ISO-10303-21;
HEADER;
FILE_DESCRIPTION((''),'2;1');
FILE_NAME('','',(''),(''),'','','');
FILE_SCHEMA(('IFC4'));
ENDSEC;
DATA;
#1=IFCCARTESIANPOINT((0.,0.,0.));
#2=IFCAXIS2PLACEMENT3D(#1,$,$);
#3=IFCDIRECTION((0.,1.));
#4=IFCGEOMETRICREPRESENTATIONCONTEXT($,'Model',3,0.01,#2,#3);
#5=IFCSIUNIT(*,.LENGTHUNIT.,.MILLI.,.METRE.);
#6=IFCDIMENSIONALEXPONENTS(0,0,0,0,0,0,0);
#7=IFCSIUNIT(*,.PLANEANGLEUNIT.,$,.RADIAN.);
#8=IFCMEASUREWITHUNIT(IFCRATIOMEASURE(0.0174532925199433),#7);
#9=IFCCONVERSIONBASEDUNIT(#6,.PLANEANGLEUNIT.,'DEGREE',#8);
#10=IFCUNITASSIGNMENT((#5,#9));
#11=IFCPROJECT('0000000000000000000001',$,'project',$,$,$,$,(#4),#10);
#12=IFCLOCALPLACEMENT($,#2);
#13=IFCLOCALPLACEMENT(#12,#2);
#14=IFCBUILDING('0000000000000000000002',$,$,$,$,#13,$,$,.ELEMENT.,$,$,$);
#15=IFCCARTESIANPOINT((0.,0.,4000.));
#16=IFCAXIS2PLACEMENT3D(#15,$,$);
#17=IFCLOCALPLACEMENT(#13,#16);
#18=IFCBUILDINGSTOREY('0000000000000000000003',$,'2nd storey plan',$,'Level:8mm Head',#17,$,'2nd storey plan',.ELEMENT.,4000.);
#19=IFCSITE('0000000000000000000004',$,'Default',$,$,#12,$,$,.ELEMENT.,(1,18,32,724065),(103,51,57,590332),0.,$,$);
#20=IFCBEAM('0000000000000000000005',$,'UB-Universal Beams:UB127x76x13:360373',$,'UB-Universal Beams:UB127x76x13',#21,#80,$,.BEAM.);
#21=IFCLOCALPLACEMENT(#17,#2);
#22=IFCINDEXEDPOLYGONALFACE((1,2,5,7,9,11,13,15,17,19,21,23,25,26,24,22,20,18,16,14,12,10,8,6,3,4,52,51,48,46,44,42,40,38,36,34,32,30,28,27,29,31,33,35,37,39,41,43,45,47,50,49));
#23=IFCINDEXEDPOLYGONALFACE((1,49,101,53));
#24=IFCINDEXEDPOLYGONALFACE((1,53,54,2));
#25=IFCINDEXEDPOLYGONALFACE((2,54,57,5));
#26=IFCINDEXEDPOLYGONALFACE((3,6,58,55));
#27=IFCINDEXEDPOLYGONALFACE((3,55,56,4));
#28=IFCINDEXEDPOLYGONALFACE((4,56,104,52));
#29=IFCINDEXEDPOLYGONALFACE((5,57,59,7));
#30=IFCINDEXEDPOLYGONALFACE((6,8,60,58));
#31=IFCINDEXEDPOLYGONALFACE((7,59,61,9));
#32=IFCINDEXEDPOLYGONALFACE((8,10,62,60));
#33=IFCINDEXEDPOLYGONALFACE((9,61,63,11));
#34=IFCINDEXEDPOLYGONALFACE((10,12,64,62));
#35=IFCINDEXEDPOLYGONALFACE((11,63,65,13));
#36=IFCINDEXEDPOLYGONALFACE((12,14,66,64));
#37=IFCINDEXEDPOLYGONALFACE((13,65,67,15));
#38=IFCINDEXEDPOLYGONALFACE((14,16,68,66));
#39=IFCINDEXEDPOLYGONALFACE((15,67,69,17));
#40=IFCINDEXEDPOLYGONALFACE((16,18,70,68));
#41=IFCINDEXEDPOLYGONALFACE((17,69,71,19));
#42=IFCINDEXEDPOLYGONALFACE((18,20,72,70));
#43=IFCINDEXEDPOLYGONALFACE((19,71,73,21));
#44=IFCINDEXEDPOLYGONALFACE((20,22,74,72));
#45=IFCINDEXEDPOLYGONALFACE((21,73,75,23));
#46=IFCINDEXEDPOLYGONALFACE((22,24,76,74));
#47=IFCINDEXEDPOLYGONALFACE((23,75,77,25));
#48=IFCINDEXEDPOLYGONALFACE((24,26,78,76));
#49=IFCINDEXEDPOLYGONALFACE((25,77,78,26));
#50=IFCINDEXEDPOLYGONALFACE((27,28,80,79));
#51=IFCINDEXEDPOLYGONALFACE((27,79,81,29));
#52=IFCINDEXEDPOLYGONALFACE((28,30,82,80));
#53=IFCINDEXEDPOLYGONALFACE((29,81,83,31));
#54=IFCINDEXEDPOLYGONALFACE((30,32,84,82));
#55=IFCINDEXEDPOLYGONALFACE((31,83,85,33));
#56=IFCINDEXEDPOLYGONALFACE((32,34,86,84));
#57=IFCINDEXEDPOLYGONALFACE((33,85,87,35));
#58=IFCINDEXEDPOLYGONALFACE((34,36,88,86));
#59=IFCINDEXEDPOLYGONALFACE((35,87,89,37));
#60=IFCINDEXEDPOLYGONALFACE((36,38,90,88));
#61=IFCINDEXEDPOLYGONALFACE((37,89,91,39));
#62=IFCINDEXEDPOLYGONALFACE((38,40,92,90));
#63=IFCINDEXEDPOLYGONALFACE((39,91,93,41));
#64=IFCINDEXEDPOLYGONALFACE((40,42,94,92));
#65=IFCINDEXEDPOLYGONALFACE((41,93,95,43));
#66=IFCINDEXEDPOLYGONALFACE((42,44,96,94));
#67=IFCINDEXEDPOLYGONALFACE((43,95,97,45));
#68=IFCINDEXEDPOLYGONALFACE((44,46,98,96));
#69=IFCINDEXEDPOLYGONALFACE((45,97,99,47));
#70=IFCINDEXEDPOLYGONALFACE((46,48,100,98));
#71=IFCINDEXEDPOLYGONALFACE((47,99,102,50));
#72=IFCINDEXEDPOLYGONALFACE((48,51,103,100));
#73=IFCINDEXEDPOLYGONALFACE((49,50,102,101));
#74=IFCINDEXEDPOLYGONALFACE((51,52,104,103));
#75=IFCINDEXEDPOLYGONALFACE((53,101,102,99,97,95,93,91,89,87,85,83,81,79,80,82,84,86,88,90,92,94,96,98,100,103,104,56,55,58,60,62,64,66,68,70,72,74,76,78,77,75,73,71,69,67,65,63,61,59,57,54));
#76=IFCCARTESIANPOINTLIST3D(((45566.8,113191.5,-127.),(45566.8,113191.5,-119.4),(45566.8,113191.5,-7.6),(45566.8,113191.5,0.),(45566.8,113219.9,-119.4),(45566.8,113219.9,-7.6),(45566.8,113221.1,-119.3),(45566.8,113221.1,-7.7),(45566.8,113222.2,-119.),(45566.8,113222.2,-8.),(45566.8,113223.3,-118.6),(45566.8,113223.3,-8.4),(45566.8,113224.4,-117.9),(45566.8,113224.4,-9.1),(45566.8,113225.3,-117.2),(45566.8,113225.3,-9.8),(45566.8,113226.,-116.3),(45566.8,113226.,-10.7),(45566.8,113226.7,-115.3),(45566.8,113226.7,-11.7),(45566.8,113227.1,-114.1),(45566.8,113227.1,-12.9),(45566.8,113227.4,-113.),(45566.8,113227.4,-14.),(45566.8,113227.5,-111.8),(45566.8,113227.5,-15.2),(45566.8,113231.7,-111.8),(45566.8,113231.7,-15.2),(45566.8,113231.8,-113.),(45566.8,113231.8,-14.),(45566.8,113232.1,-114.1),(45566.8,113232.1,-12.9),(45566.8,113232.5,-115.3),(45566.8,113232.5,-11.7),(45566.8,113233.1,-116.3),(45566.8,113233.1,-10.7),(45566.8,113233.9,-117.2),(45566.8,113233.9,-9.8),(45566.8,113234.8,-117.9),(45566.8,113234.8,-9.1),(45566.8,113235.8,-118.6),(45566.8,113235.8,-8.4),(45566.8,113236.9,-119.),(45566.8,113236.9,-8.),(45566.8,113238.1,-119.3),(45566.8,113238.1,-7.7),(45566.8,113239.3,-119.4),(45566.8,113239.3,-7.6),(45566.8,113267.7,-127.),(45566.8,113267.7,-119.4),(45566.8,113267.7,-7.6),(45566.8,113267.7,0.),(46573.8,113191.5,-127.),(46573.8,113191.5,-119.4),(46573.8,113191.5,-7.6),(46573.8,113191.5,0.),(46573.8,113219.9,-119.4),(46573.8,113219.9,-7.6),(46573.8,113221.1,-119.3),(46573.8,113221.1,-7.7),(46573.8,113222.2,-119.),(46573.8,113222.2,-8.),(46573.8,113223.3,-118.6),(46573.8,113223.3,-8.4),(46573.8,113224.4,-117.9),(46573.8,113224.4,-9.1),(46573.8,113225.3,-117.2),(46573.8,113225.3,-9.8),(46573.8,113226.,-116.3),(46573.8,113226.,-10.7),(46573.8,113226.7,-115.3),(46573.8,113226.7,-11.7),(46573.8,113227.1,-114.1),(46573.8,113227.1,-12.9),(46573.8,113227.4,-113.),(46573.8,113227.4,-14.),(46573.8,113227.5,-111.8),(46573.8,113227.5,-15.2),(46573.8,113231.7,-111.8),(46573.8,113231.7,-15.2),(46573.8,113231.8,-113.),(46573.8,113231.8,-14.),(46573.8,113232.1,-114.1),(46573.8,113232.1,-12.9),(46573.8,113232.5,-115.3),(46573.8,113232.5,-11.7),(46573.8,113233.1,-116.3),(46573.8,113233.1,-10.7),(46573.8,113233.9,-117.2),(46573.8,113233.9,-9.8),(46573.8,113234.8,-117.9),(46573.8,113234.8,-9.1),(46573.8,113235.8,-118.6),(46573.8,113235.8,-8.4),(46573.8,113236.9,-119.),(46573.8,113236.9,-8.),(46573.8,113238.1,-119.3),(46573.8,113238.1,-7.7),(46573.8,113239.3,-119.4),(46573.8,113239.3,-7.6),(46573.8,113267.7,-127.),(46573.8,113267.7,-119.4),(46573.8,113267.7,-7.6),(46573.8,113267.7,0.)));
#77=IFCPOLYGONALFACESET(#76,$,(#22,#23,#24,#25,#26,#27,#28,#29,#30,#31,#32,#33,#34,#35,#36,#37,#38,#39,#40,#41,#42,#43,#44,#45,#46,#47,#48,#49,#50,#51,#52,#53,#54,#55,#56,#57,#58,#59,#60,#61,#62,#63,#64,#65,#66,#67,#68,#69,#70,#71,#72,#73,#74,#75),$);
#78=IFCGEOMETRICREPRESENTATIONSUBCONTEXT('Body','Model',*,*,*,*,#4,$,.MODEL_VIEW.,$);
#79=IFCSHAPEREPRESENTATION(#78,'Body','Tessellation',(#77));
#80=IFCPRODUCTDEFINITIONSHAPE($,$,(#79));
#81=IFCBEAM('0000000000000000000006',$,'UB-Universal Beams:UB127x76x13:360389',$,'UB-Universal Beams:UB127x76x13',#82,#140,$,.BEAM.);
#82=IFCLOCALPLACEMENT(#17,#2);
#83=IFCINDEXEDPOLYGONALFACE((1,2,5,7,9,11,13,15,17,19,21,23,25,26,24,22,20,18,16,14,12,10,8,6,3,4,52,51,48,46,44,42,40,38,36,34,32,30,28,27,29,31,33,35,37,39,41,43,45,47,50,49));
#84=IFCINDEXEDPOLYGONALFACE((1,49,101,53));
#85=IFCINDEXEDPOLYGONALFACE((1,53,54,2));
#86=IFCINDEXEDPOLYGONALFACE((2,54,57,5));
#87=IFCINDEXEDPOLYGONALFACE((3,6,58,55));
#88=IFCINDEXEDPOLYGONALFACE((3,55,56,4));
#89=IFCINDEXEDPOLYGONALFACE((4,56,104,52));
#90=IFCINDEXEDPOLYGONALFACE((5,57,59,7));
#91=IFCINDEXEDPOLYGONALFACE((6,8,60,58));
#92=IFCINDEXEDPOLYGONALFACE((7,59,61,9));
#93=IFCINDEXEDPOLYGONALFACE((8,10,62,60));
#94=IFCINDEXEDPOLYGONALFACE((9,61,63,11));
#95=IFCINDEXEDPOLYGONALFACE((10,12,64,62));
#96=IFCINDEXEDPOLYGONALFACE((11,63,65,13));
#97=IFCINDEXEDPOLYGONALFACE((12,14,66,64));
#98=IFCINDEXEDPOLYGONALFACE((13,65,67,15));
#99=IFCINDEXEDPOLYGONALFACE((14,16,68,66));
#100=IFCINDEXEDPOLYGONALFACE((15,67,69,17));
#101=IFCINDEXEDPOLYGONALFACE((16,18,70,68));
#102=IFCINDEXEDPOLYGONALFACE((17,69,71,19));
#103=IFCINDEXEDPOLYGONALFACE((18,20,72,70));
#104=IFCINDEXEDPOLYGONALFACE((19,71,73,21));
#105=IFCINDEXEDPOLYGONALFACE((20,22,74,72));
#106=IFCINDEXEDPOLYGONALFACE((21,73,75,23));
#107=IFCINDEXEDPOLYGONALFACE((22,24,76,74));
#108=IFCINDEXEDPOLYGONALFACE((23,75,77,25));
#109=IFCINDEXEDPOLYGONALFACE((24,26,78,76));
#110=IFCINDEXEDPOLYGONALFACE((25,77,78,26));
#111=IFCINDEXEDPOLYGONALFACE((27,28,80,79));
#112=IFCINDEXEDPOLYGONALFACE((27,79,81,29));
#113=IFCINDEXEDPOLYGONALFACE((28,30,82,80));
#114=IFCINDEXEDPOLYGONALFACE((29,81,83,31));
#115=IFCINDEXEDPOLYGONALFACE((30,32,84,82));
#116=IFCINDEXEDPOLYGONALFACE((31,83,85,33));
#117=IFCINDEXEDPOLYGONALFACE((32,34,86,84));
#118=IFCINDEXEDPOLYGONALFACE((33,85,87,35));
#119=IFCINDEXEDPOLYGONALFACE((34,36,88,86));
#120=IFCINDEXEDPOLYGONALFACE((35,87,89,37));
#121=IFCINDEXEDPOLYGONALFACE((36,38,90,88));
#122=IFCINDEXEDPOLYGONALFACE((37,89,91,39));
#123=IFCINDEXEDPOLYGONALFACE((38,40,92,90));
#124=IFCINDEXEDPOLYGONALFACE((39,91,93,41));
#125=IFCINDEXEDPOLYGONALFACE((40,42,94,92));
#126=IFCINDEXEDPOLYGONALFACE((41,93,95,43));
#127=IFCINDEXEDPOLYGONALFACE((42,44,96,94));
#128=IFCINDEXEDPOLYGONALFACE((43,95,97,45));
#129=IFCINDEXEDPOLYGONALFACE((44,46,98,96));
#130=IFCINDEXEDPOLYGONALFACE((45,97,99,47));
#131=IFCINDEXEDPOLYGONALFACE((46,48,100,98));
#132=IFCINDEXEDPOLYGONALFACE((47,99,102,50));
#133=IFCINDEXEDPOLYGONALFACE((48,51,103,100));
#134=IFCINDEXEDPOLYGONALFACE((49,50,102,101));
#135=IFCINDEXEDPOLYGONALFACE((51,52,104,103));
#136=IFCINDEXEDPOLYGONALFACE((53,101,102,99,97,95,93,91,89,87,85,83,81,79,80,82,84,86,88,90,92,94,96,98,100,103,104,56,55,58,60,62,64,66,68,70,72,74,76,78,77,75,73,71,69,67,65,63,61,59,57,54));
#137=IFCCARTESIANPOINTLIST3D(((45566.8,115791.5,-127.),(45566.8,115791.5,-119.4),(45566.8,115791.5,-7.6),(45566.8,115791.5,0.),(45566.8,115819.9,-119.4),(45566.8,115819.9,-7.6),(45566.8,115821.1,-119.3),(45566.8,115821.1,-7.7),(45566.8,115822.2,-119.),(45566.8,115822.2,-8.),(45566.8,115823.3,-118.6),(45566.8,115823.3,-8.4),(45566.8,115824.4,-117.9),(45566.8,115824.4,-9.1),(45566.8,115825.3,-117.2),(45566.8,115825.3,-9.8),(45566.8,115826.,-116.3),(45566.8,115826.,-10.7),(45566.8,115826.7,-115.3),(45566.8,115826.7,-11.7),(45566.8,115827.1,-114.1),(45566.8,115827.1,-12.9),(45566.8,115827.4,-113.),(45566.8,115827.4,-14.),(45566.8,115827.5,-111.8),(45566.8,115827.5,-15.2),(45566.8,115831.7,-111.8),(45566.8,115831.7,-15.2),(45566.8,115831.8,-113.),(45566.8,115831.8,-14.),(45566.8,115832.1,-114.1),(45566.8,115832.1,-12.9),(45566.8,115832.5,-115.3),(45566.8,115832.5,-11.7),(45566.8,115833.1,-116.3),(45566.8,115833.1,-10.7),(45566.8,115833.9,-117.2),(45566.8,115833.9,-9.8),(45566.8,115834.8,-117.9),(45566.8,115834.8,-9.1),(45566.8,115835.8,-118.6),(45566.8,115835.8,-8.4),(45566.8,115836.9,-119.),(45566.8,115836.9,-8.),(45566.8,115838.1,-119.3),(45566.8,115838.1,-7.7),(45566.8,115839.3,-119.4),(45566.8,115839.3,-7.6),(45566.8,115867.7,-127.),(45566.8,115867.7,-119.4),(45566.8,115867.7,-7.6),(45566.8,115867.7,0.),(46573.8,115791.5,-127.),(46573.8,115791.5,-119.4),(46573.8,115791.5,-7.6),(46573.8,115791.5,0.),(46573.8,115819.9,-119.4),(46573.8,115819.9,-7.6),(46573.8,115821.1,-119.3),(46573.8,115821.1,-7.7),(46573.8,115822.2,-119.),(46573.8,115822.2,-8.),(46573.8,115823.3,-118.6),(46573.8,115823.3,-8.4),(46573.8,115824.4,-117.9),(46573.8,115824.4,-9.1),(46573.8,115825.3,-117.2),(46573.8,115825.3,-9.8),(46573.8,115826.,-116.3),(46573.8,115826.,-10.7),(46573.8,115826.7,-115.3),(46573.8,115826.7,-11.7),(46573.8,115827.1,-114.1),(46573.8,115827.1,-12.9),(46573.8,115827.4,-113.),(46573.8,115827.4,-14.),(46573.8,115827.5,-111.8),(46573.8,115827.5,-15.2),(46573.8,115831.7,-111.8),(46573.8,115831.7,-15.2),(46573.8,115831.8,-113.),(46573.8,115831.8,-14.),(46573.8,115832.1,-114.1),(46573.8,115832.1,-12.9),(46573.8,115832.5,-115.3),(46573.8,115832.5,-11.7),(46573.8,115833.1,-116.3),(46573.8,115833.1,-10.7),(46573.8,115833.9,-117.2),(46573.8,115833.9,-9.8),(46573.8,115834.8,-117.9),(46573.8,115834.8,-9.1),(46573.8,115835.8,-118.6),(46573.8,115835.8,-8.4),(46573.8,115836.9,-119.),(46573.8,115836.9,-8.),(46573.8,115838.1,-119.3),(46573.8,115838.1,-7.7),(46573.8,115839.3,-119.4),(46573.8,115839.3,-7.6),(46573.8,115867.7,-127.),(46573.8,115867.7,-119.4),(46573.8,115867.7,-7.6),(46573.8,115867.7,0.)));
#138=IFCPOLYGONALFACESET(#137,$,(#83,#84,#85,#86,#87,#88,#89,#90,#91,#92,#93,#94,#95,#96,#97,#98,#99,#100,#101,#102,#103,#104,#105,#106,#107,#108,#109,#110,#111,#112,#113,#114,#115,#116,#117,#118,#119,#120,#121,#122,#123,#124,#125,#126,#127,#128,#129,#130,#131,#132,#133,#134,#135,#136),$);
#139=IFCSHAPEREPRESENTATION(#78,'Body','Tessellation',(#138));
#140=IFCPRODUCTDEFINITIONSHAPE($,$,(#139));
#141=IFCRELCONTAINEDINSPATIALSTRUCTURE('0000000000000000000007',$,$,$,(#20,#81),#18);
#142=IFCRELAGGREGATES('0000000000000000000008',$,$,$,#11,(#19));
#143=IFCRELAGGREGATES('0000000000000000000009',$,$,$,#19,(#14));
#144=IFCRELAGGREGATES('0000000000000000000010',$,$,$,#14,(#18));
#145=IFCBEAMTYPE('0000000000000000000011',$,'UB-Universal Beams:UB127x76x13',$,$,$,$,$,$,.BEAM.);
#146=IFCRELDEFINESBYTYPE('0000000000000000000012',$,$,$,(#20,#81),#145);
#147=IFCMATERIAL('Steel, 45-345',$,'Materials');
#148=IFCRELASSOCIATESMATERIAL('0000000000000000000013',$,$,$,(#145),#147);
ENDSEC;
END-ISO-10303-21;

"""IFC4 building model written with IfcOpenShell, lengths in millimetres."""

from ifc_helpers import new_model, entity, si_unit, converted_unit, direction, frame, origin, place, context, subcontext, project, spatial, indexed_curve, outline, extrude, source, transform, mapped, material, type_object, type_shapes, element, save


model = new_model("IFC4")

# Units and contexts
model_context = context("Model", 3, precision=0.01, world=origin(), true_north=direction((0.0, 1.0)))
body_context = subcontext(model_context, "Body", "Model", "MODEL_VIEW")
ifc_project = project(units=[si_unit("LENGTHUNIT", "METRE", prefix="MILLI"), converted_unit("PLANEANGLEUNIT", "DEGREE", entity("IfcRatioMeasure", 0.0174532925199433), si_unit("PLANEANGLEUNIT", "RADIAN"), dimensions=[0, 0, 0, 0, 0, 0, 0])], contexts=[model_context])

# Site, building, storey
site_placement = place(None, origin())
site = spatial("IfcSite", under=ifc_project, at=site_placement, Name="Default", CompositionType="ELEMENT", RefLatitude=(1, 18, 32, 724065), RefLongitude=(103, 51, 57, 590332), RefElevation=0.0)
building_placement = place(site_placement, origin())
building = spatial("IfcBuilding", under=site, at=building_placement, CompositionType="ELEMENT")
storey_placement = place(building_placement, frame((0.0, 0.0, 4000.0)))
storey = spatial("IfcBuildingStorey", under=building, at=storey_placement, Name="2nd storey plan", ObjectType="Level:8mm Head", LongName="2nd storey plan", CompositionType="ELEMENT", Elevation=4000.0)

# Beams
ifc_material_1 = material(Name="Steel, 45-345", Category="Materials")
beam_type_1 = type_object("IfcBeamType", Name="UB-Universal Beams:UB127x76x13", PredefinedType="BEAM", material=ifc_material_1)
shared_shape_1 = source(origin(), body_context, "Body", "SweptSolid", [
    extrude(outline(indexed_curve([(-63.5, -38.1), (-55.9, -38.1), (-55.9, -9.7), (-55.8, -8.5), (-55.5, -7.4), (-55.1, -6.2), (-54.4, -5.2), (-53.7, -4.3), (-52.8, -3.6), (-51.8, -2.9), (-50.6, -2.5), (-49.5, -2.2), (-48.3, -2.1), (48.3, -2.1), (49.5, -2.2), (50.6, -2.5), (51.8, -2.9), (52.8, -3.6), (53.7, -4.3), (54.4, -5.2), (55.1, -6.2), (55.5, -7.4), (55.8, -8.5), (55.9, -9.7), (55.9, -38.1), (63.5, -38.1), (63.5, 38.1), (55.9, 38.1), (55.9, 9.7), (55.8, 8.5), (55.5, 7.4), (55.1, 6.2), (54.4, 5.2), (53.7, 4.3), (52.8, 3.6), (51.8, 2.9), (50.6, 2.5), (49.5, 2.2), (48.3, 2.1), (-48.3, 2.1), (-49.5, 2.2), (-50.6, 2.5), (-51.8, 2.9), (-52.8, 3.6), (-53.7, 4.3), (-54.4, 5.2), (-55.1, 6.2), (-55.5, 7.4), (-55.8, 8.5), (-55.9, 9.7), (-55.9, 38.1), (-63.5, 38.1), (-63.5, -38.1)], self_intersect=False)), frame((-570.0, 0.0, 0.0), z_axis=(1.0, 0.0, 0.0), x_axis=(0.0, 0.0, -1.0)), (0.0, 0.0, 1.0), 1007.0),
])
type_shapes(beam_type_1, [shared_shape_1])
for number, where, name in (
    (1, (46136.8, 113229.6, -63.5), "UB-Universal Beams:UB127x76x13:360373"),
    (2, (46136.8, 115829.6, -63.5), "UB-Universal Beams:UB127x76x13:360389"),
):
    element("IfcBeam", number, at=place(storey_placement, frame(where)), inside=storey, type_object=beam_type_1, Name=name, ObjectType="UB-Universal Beams:UB127x76x13", PredefinedType="BEAM", context=body_context, shape_type="MappedRepresentation", body=[
        mapped(shared_shape_1, transform((0.0, 0.0, 0.0), scale=1.0)),
    ])

save(model, "model.ifc")
